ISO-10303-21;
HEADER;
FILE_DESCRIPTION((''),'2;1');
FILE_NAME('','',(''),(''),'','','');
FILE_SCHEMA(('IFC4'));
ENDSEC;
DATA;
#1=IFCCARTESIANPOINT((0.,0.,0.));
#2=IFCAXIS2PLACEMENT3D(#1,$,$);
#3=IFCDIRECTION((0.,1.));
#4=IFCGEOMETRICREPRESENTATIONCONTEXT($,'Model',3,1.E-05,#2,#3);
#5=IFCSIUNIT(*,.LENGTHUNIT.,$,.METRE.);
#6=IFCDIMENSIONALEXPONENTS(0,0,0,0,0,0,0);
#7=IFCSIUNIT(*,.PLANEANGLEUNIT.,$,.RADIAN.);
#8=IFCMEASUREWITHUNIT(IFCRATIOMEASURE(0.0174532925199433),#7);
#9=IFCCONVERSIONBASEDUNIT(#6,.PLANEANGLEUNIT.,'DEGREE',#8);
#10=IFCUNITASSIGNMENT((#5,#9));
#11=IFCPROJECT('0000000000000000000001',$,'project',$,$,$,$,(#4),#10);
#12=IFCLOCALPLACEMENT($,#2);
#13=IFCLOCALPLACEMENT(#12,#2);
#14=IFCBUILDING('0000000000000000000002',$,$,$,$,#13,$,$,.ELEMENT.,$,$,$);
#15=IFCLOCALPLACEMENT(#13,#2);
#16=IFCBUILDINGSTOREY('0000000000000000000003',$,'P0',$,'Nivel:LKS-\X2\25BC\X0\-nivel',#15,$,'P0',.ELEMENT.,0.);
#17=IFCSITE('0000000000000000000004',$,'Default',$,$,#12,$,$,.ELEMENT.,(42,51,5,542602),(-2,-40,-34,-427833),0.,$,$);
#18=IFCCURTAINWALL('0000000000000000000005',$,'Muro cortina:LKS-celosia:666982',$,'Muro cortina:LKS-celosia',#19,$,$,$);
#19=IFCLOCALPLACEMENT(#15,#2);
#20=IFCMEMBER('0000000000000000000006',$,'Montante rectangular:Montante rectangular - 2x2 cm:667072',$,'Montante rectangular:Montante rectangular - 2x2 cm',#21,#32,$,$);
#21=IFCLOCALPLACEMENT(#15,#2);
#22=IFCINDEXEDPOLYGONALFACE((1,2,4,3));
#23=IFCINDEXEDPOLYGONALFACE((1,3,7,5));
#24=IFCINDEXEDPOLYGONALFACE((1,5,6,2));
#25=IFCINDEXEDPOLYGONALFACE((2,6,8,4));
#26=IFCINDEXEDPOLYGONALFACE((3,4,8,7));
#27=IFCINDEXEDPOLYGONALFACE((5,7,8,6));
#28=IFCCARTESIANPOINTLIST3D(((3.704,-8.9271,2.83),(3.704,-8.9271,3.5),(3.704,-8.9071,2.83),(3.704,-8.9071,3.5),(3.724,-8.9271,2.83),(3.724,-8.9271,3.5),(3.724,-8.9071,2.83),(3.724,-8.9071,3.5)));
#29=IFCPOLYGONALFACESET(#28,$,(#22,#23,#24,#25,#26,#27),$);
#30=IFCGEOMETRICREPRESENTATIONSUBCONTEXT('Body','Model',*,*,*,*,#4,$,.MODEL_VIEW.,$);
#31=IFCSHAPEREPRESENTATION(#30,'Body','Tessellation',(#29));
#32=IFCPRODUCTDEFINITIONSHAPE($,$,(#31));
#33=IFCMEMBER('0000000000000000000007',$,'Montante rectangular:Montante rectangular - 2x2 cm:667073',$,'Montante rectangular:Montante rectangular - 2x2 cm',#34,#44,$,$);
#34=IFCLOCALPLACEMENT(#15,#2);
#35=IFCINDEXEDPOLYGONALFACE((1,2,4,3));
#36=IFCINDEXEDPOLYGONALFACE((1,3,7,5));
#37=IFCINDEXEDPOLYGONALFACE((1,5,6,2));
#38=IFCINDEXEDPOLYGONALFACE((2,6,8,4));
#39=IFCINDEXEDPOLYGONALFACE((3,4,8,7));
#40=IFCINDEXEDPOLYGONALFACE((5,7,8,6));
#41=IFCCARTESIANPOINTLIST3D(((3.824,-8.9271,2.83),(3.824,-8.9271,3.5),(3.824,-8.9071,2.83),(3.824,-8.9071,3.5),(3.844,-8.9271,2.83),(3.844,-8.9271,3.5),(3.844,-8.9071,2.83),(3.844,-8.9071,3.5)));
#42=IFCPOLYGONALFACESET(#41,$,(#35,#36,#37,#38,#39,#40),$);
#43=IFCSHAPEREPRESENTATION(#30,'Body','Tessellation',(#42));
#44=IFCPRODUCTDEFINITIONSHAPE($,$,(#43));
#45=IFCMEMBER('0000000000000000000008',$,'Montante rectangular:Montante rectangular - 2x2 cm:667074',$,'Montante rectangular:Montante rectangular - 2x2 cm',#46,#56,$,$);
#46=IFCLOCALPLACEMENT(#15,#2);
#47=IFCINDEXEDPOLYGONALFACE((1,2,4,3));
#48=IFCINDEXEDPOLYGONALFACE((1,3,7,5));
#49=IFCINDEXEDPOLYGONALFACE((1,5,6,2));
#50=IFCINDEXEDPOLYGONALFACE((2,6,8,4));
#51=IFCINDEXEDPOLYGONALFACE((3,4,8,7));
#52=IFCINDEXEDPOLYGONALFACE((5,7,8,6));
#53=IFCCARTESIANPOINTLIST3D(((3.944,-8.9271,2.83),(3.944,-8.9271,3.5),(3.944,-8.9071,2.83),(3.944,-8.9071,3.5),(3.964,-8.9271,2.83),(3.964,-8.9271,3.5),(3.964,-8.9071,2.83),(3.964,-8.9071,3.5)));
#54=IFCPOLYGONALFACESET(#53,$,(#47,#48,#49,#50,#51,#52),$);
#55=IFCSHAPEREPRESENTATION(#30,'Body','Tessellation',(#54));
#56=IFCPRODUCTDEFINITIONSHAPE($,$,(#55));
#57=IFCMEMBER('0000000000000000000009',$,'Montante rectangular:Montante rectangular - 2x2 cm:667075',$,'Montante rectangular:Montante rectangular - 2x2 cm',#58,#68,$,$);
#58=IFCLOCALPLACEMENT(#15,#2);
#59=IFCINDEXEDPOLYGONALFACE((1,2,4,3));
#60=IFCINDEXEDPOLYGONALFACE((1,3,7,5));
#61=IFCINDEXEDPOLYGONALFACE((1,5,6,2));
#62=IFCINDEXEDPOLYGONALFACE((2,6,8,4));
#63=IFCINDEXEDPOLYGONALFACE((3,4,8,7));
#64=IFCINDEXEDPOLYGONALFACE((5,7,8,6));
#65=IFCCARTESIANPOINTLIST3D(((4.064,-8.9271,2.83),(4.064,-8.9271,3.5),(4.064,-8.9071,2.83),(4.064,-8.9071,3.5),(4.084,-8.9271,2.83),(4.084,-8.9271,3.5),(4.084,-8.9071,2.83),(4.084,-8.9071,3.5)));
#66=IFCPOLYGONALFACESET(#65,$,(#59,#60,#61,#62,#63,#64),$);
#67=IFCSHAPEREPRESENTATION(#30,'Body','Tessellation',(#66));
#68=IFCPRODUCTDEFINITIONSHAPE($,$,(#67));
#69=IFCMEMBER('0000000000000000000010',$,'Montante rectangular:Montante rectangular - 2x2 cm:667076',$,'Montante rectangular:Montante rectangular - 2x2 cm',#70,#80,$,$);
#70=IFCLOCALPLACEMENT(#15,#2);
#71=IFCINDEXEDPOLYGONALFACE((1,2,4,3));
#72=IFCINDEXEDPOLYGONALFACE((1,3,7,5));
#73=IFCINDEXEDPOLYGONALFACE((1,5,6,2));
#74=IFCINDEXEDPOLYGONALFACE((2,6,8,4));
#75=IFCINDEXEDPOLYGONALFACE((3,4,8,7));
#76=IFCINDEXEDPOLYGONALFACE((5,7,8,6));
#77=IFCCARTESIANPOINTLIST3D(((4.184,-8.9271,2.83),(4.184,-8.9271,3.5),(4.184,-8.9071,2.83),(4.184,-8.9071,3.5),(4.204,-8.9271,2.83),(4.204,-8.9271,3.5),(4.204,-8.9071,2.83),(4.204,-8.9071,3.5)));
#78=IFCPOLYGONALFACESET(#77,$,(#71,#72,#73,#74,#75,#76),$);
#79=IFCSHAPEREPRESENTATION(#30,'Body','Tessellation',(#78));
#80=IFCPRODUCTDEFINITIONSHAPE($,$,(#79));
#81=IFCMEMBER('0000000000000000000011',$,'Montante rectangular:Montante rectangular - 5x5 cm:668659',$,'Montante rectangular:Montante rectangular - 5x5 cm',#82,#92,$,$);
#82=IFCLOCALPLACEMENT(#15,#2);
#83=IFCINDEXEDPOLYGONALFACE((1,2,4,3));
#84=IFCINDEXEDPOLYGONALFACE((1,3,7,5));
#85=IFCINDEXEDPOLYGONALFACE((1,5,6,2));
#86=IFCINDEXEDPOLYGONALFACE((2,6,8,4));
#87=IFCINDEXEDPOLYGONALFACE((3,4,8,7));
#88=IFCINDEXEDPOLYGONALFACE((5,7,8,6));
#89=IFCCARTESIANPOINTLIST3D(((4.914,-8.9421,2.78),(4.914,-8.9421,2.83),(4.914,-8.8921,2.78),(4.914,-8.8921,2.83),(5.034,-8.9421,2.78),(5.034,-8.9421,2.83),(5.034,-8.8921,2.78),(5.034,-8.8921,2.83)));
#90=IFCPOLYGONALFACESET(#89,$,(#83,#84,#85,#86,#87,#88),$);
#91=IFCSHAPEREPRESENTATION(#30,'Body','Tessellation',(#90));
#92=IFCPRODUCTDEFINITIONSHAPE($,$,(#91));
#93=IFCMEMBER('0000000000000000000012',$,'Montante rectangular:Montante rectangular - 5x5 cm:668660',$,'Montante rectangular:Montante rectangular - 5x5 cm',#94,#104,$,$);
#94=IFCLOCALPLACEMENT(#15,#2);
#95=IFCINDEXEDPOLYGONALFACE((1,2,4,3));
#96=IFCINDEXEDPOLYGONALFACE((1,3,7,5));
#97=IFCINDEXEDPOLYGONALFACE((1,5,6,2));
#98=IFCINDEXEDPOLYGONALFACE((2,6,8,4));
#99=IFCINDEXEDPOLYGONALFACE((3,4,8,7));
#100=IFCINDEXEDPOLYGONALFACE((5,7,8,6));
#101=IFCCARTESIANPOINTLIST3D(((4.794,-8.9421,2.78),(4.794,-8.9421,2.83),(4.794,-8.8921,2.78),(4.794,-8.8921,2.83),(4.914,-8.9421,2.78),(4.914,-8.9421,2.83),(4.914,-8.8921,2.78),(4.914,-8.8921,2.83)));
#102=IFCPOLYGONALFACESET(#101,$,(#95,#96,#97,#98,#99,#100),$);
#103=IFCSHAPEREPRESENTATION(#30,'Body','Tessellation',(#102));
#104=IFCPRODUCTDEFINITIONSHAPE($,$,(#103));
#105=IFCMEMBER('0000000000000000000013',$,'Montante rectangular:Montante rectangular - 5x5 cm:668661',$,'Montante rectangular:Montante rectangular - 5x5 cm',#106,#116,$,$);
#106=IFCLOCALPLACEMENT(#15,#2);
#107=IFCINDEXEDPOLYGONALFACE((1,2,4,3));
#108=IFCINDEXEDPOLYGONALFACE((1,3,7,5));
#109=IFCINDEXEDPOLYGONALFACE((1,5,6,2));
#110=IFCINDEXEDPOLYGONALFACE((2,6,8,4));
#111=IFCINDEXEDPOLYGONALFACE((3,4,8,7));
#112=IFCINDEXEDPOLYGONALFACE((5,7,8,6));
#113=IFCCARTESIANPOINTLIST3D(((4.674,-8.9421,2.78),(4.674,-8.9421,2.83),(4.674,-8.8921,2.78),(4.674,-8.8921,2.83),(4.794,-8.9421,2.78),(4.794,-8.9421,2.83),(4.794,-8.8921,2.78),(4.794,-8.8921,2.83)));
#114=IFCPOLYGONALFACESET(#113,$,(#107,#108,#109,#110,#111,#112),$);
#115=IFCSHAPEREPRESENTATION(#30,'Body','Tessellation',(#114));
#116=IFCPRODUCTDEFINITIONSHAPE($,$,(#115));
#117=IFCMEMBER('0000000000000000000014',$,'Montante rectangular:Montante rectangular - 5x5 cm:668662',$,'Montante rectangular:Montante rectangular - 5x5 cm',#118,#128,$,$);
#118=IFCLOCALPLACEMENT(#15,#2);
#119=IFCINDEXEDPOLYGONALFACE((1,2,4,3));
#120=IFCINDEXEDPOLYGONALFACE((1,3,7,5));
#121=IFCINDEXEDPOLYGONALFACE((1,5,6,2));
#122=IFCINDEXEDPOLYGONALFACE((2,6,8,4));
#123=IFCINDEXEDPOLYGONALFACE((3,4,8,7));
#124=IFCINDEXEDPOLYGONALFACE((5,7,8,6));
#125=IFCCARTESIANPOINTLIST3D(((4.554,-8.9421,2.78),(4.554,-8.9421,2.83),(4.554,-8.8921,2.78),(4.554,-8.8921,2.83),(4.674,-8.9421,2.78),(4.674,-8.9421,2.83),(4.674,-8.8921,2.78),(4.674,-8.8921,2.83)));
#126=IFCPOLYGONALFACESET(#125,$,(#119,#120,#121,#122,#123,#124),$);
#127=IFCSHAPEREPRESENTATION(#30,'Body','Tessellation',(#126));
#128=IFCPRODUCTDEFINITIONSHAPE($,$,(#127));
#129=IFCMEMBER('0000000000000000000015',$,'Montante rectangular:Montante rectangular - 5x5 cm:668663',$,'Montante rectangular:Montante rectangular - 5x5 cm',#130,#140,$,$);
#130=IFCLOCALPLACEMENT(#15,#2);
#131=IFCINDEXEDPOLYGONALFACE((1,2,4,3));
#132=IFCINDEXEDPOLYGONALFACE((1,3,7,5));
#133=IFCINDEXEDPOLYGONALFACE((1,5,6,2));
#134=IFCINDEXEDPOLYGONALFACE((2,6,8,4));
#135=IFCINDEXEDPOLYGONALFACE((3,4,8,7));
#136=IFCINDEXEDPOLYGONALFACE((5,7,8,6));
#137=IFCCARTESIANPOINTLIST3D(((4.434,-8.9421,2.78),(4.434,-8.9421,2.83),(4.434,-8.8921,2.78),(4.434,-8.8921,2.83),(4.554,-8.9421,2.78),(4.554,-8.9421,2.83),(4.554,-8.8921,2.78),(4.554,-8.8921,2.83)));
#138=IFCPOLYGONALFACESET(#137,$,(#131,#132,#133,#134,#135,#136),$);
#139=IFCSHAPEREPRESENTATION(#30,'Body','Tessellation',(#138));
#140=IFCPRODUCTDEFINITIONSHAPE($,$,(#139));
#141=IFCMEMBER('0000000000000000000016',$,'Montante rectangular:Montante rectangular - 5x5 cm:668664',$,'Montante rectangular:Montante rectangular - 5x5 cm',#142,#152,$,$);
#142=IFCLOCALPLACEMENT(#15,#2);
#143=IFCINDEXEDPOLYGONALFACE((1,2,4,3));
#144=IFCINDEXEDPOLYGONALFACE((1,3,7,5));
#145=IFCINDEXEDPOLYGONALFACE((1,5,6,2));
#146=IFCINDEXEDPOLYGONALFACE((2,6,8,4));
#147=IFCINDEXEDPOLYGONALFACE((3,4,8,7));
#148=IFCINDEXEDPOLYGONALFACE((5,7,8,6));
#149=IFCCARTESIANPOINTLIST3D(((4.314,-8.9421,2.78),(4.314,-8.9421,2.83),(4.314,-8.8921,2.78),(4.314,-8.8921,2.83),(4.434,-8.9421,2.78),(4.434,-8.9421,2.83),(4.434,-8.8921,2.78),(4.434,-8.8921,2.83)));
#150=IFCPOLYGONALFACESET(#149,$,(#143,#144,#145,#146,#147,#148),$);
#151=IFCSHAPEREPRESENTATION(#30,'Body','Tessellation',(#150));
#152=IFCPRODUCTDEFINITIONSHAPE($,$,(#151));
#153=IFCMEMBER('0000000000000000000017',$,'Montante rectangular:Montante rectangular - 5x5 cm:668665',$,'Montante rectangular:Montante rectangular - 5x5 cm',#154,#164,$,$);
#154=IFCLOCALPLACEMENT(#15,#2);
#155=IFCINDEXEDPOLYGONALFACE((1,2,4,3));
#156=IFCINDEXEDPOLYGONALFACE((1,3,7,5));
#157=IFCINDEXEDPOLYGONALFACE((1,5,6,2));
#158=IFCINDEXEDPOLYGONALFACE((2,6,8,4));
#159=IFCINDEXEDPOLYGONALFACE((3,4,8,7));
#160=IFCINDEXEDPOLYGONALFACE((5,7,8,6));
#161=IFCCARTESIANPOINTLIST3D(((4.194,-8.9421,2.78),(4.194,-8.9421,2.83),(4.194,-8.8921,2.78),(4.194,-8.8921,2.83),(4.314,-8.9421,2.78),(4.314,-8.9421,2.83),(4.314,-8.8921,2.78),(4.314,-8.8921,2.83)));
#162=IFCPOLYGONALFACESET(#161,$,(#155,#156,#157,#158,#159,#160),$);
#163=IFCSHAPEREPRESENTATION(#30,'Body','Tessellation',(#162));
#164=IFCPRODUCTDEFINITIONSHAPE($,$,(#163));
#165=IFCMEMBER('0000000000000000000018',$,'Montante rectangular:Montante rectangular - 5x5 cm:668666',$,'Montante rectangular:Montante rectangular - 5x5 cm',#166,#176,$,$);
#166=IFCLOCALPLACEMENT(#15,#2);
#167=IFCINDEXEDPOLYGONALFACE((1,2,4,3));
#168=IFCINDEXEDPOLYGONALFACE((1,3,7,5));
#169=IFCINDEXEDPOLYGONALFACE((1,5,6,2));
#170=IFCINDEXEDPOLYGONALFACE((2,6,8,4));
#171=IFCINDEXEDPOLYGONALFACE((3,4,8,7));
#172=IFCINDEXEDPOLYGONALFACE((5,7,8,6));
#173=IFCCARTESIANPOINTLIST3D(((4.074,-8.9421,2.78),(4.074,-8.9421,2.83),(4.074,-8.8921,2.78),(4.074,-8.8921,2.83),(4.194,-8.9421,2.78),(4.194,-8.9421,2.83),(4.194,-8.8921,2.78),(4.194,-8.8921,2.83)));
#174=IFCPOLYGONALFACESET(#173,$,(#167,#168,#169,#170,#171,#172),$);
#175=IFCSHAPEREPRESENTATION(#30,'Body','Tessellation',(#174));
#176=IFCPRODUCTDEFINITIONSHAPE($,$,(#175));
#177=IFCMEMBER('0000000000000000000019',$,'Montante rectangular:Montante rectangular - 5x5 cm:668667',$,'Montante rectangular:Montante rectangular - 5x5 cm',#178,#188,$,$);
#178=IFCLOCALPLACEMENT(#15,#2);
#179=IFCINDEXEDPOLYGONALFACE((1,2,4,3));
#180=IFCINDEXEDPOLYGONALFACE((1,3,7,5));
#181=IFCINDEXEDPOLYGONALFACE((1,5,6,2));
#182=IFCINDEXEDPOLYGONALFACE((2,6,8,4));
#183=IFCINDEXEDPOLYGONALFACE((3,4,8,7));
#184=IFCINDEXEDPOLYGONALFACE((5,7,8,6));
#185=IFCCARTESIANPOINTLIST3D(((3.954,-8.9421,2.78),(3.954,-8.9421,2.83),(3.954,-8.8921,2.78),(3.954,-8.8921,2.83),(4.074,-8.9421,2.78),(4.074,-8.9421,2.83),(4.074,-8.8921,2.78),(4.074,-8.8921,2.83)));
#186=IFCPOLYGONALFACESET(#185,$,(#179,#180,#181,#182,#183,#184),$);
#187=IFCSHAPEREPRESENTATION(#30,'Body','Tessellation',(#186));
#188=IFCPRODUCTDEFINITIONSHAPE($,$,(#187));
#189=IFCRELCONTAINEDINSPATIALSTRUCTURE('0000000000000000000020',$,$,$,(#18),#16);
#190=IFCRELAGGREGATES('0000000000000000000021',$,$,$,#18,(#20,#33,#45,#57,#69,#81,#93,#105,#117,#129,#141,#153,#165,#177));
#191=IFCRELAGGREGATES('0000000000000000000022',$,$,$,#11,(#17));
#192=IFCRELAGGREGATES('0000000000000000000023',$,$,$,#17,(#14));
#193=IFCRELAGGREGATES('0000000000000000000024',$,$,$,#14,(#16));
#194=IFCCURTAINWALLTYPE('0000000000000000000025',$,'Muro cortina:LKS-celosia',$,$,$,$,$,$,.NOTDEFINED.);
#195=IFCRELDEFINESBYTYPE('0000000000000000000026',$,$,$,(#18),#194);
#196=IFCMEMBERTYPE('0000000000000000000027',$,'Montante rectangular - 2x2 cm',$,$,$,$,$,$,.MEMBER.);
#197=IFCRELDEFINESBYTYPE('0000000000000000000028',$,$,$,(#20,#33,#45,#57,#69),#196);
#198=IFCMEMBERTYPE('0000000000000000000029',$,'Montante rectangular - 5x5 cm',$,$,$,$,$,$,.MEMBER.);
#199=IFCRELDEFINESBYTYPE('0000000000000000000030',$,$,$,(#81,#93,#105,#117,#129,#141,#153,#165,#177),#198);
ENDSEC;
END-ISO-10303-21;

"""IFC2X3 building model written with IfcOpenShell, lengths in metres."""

from ifc_helpers import new_model, entity, si_unit, converted_unit, direction, frame, origin, origin_2d_with_axis, place, context, subcontext, project, spatial, rectangle, extrude, source, transform, mapped, type_object, type_shapes, element, aggregate, save


model = new_model("IFC2X3")

# Units and contexts
model_context = context("Model", 3, precision=1e-05, world=origin(), true_north=direction((0.0, 1.0)))
body_context = subcontext(model_context, "Body", "Model", "MODEL_VIEW")
ifc_project = project(units=[si_unit("LENGTHUNIT", "METRE"), converted_unit("PLANEANGLEUNIT", "DEGREE", entity("IfcRatioMeasure", 0.0174532925199433), si_unit("PLANEANGLEUNIT", "RADIAN"), dimensions=[0, 0, 0, 0, 0, 0, 0])], contexts=[model_context])

# Site, building, storey
site_placement = place(None, origin())
site = spatial("IfcSite", under=ifc_project, at=site_placement, Name="Default", CompositionType="ELEMENT", RefLatitude=(42, 51, 5, 542602), RefLongitude=(-2, -40, -34, -427833), RefElevation=0.0)
building_placement = place(site_placement, origin())
building = spatial("IfcBuilding", under=site, at=building_placement, CompositionType="ELEMENT")
storey_placement = place(building_placement, origin())
storey = spatial("IfcBuildingStorey", under=building, at=storey_placement, Name="P0", ObjectType="Nivel:LKS-▼-nivel", LongName="P0", CompositionType="ELEMENT", Elevation=0.0)

# Curtain wall, members
curtain_wall_type = type_object("IfcCurtainWallType", Name="Muro cortina:LKS-celosia", PredefinedType="NOTDEFINED")
curtain_wall_placement = place(storey_placement, origin())
curtain_wall = element("IfcCurtainWall", 1, at=curtain_wall_placement, inside=storey, type_object=curtain_wall_type, Name="Muro cortina:LKS-celosia:666982", ObjectType="Muro cortina:LKS-celosia")
member_type_1 = type_object("IfcMemberType", Name="Montante rectangular - 2x2 cm", PredefinedType="MEMBER")
shared_shape_1 = source(origin(), body_context, "Body", "SweptSolid", [
    extrude(rectangle(XDim=0.02, YDim=0.02, at=origin_2d_with_axis()), frame((0.0, -0.1, -0.67), z_axis=(0.0, 0.0, 1.0), x_axis=(0.0, -1.0, 0.0)), (0.0, 0.0, 1.0), 0.67),
])
type_shapes(member_type_1, [shared_shape_1])
member_1_placement = place(storey_placement, frame((3.714, -9.0171, 2.83), z_axis=(0.0, 0.0, -1.0), x_axis=(1.0, 0.0, 0.0)))
member_1 = element("IfcMember", 2, at=member_1_placement, type_object=member_type_1, Name="Montante rectangular:Montante rectangular - 2x2 cm:667072", ObjectType="Montante rectangular:Montante rectangular - 2x2 cm", context=body_context, shape_type="MappedRepresentation", body=[
    mapped(shared_shape_1, transform((0.0, 0.0, 0.0), scale=1.0)),
])
member_2_placement = place(storey_placement, frame((3.834, -9.0171, 2.83), z_axis=(0.0, 0.0, -1.0), x_axis=(1.0, 0.0, 0.0)))
member_2 = element("IfcMember", 3, at=member_2_placement, type_object=member_type_1, Name="Montante rectangular:Montante rectangular - 2x2 cm:667073", ObjectType="Montante rectangular:Montante rectangular - 2x2 cm", context=body_context, shape_type="MappedRepresentation", body=[
    mapped(shared_shape_1, transform((0.0, 0.0, 0.0), scale=1.0)),
])
member_3_placement = place(storey_placement, frame((3.954, -9.0171, 2.83), z_axis=(0.0, 0.0, -1.0), x_axis=(1.0, 0.0, 0.0)))
member_3 = element("IfcMember", 4, at=member_3_placement, type_object=member_type_1, Name="Montante rectangular:Montante rectangular - 2x2 cm:667074", ObjectType="Montante rectangular:Montante rectangular - 2x2 cm", context=body_context, shape_type="MappedRepresentation", body=[
    mapped(shared_shape_1, transform((0.0, 0.0, 0.0), scale=1.0)),
])
member_4_placement = place(storey_placement, frame((4.074, -9.0171, 2.83), z_axis=(0.0, 0.0, -1.0), x_axis=(1.0, 0.0, 0.0)))
member_4 = element("IfcMember", 5, at=member_4_placement, type_object=member_type_1, Name="Montante rectangular:Montante rectangular - 2x2 cm:667075", ObjectType="Montante rectangular:Montante rectangular - 2x2 cm", context=body_context, shape_type="MappedRepresentation", body=[
    mapped(shared_shape_1, transform((0.0, 0.0, 0.0), scale=1.0)),
])
member_5_placement = place(storey_placement, frame((4.194, -9.0171, 2.83), z_axis=(0.0, 0.0, -1.0), x_axis=(1.0, 0.0, 0.0)))
member_5 = element("IfcMember", 6, at=member_5_placement, type_object=member_type_1, Name="Montante rectangular:Montante rectangular - 2x2 cm:667076", ObjectType="Montante rectangular:Montante rectangular - 2x2 cm", context=body_context, shape_type="MappedRepresentation", body=[
    mapped(shared_shape_1, transform((0.0, 0.0, 0.0), scale=1.0)),
])
member_type_2 = type_object("IfcMemberType", Name="Montante rectangular - 5x5 cm", PredefinedType="MEMBER")
shared_shape_2 = source(origin(), body_context, "Body", "SweptSolid", [
    extrude(rectangle(XDim=0.05, YDim=0.05, at=origin_2d_with_axis()), frame((-0.025, -0.1, -0.12), z_axis=(0.0, 0.0, 1.0), x_axis=(0.0, -1.0, 0.0)), (0.0, 0.0, 1.0), 0.12),
])
type_shapes(member_type_2, [shared_shape_2])
member_6_placement = place(storey_placement, frame((4.914, -9.0171, 2.78), z_axis=(-1.0, 0.0, 0.0), x_axis=(0.0, 0.0, -1.0)))
member_6 = element("IfcMember", 7, at=member_6_placement, type_object=member_type_2, Name="Montante rectangular:Montante rectangular - 5x5 cm:668659", ObjectType="Montante rectangular:Montante rectangular - 5x5 cm", context=body_context, shape_type="MappedRepresentation", body=[
    mapped(shared_shape_2, transform((0.0, 0.0, 0.0), scale=1.0)),
])
member_7_placement = place(storey_placement, frame((4.794, -9.0171, 2.78), z_axis=(-1.0, 0.0, 0.0), x_axis=(0.0, 0.0, -1.0)))
member_7 = element("IfcMember", 8, at=member_7_placement, type_object=member_type_2, Name="Montante rectangular:Montante rectangular - 5x5 cm:668660", ObjectType="Montante rectangular:Montante rectangular - 5x5 cm", context=body_context, shape_type="MappedRepresentation", body=[
    mapped(shared_shape_2, transform((0.0, 0.0, 0.0), scale=1.0)),
])
member_8_placement = place(storey_placement, frame((4.674, -9.0171, 2.78), z_axis=(-1.0, 0.0, 0.0), x_axis=(0.0, 0.0, -1.0)))
member_8 = element("IfcMember", 9, at=member_8_placement, type_object=member_type_2, Name="Montante rectangular:Montante rectangular - 5x5 cm:668661", ObjectType="Montante rectangular:Montante rectangular - 5x5 cm", context=body_context, shape_type="MappedRepresentation", body=[
    mapped(shared_shape_2, transform((0.0, 0.0, 0.0), scale=1.0)),
])
member_9_placement = place(storey_placement, frame((4.554, -9.0171, 2.78), z_axis=(-1.0, 0.0, 0.0), x_axis=(0.0, 0.0, -1.0)))
member_9 = element("IfcMember", 10, at=member_9_placement, type_object=member_type_2, Name="Montante rectangular:Montante rectangular - 5x5 cm:668662", ObjectType="Montante rectangular:Montante rectangular - 5x5 cm", context=body_context, shape_type="MappedRepresentation", body=[
    mapped(shared_shape_2, transform((0.0, 0.0, 0.0), scale=1.0)),
])
member_10_placement = place(storey_placement, frame((4.434, -9.0171, 2.78), z_axis=(-1.0, 0.0, 0.0), x_axis=(0.0, 0.0, -1.0)))
member_10 = element("IfcMember", 11, at=member_10_placement, type_object=member_type_2, Name="Montante rectangular:Montante rectangular - 5x5 cm:668663", ObjectType="Montante rectangular:Montante rectangular - 5x5 cm", context=body_context, shape_type="MappedRepresentation", body=[
    mapped(shared_shape_2, transform((0.0, 0.0, 0.0), scale=1.0)),
])
member_11_placement = place(storey_placement, frame((4.314, -9.0171, 2.78), z_axis=(-1.0, 0.0, 0.0), x_axis=(0.0, 0.0, -1.0)))
member_11 = element("IfcMember", 12, at=member_11_placement, type_object=member_type_2, Name="Montante rectangular:Montante rectangular - 5x5 cm:668664", ObjectType="Montante rectangular:Montante rectangular - 5x5 cm", context=body_context, shape_type="MappedRepresentation", body=[
    mapped(shared_shape_2, transform((0.0, 0.0, 0.0), scale=1.0)),
])
member_12_placement = place(storey_placement, frame((4.194, -9.0171, 2.78), z_axis=(-1.0, 0.0, 0.0), x_axis=(0.0, 0.0, -1.0)))
member_12 = element("IfcMember", 13, at=member_12_placement, type_object=member_type_2, Name="Montante rectangular:Montante rectangular - 5x5 cm:668665", ObjectType="Montante rectangular:Montante rectangular - 5x5 cm", context=body_context, shape_type="MappedRepresentation", body=[
    mapped(shared_shape_2, transform((0.0, 0.0, 0.0), scale=1.0)),
])
member_13_placement = place(storey_placement, frame((4.074, -9.0171, 2.78), z_axis=(-1.0, 0.0, 0.0), x_axis=(0.0, 0.0, -1.0)))
member_13 = element("IfcMember", 14, at=member_13_placement, type_object=member_type_2, Name="Montante rectangular:Montante rectangular - 5x5 cm:668666", ObjectType="Montante rectangular:Montante rectangular - 5x5 cm", context=body_context, shape_type="MappedRepresentation", body=[
    mapped(shared_shape_2, transform((0.0, 0.0, 0.0), scale=1.0)),
])
member_14_placement = place(storey_placement, frame((3.954, -9.0171, 2.78), z_axis=(-1.0, 0.0, 0.0), x_axis=(0.0, 0.0, -1.0)))
member_14 = element("IfcMember", 15, at=member_14_placement, type_object=member_type_2, Name="Montante rectangular:Montante rectangular - 5x5 cm:668667", ObjectType="Montante rectangular:Montante rectangular - 5x5 cm", context=body_context, shape_type="MappedRepresentation", body=[
    mapped(shared_shape_2, transform((0.0, 0.0, 0.0), scale=1.0)),
])
aggregate(curtain_wall, [member_1, member_2, member_3, member_4, member_5, member_6, member_7, member_8, member_9, member_10, member_11, member_12, member_13, member_14])

save(model, "model.ifc")
